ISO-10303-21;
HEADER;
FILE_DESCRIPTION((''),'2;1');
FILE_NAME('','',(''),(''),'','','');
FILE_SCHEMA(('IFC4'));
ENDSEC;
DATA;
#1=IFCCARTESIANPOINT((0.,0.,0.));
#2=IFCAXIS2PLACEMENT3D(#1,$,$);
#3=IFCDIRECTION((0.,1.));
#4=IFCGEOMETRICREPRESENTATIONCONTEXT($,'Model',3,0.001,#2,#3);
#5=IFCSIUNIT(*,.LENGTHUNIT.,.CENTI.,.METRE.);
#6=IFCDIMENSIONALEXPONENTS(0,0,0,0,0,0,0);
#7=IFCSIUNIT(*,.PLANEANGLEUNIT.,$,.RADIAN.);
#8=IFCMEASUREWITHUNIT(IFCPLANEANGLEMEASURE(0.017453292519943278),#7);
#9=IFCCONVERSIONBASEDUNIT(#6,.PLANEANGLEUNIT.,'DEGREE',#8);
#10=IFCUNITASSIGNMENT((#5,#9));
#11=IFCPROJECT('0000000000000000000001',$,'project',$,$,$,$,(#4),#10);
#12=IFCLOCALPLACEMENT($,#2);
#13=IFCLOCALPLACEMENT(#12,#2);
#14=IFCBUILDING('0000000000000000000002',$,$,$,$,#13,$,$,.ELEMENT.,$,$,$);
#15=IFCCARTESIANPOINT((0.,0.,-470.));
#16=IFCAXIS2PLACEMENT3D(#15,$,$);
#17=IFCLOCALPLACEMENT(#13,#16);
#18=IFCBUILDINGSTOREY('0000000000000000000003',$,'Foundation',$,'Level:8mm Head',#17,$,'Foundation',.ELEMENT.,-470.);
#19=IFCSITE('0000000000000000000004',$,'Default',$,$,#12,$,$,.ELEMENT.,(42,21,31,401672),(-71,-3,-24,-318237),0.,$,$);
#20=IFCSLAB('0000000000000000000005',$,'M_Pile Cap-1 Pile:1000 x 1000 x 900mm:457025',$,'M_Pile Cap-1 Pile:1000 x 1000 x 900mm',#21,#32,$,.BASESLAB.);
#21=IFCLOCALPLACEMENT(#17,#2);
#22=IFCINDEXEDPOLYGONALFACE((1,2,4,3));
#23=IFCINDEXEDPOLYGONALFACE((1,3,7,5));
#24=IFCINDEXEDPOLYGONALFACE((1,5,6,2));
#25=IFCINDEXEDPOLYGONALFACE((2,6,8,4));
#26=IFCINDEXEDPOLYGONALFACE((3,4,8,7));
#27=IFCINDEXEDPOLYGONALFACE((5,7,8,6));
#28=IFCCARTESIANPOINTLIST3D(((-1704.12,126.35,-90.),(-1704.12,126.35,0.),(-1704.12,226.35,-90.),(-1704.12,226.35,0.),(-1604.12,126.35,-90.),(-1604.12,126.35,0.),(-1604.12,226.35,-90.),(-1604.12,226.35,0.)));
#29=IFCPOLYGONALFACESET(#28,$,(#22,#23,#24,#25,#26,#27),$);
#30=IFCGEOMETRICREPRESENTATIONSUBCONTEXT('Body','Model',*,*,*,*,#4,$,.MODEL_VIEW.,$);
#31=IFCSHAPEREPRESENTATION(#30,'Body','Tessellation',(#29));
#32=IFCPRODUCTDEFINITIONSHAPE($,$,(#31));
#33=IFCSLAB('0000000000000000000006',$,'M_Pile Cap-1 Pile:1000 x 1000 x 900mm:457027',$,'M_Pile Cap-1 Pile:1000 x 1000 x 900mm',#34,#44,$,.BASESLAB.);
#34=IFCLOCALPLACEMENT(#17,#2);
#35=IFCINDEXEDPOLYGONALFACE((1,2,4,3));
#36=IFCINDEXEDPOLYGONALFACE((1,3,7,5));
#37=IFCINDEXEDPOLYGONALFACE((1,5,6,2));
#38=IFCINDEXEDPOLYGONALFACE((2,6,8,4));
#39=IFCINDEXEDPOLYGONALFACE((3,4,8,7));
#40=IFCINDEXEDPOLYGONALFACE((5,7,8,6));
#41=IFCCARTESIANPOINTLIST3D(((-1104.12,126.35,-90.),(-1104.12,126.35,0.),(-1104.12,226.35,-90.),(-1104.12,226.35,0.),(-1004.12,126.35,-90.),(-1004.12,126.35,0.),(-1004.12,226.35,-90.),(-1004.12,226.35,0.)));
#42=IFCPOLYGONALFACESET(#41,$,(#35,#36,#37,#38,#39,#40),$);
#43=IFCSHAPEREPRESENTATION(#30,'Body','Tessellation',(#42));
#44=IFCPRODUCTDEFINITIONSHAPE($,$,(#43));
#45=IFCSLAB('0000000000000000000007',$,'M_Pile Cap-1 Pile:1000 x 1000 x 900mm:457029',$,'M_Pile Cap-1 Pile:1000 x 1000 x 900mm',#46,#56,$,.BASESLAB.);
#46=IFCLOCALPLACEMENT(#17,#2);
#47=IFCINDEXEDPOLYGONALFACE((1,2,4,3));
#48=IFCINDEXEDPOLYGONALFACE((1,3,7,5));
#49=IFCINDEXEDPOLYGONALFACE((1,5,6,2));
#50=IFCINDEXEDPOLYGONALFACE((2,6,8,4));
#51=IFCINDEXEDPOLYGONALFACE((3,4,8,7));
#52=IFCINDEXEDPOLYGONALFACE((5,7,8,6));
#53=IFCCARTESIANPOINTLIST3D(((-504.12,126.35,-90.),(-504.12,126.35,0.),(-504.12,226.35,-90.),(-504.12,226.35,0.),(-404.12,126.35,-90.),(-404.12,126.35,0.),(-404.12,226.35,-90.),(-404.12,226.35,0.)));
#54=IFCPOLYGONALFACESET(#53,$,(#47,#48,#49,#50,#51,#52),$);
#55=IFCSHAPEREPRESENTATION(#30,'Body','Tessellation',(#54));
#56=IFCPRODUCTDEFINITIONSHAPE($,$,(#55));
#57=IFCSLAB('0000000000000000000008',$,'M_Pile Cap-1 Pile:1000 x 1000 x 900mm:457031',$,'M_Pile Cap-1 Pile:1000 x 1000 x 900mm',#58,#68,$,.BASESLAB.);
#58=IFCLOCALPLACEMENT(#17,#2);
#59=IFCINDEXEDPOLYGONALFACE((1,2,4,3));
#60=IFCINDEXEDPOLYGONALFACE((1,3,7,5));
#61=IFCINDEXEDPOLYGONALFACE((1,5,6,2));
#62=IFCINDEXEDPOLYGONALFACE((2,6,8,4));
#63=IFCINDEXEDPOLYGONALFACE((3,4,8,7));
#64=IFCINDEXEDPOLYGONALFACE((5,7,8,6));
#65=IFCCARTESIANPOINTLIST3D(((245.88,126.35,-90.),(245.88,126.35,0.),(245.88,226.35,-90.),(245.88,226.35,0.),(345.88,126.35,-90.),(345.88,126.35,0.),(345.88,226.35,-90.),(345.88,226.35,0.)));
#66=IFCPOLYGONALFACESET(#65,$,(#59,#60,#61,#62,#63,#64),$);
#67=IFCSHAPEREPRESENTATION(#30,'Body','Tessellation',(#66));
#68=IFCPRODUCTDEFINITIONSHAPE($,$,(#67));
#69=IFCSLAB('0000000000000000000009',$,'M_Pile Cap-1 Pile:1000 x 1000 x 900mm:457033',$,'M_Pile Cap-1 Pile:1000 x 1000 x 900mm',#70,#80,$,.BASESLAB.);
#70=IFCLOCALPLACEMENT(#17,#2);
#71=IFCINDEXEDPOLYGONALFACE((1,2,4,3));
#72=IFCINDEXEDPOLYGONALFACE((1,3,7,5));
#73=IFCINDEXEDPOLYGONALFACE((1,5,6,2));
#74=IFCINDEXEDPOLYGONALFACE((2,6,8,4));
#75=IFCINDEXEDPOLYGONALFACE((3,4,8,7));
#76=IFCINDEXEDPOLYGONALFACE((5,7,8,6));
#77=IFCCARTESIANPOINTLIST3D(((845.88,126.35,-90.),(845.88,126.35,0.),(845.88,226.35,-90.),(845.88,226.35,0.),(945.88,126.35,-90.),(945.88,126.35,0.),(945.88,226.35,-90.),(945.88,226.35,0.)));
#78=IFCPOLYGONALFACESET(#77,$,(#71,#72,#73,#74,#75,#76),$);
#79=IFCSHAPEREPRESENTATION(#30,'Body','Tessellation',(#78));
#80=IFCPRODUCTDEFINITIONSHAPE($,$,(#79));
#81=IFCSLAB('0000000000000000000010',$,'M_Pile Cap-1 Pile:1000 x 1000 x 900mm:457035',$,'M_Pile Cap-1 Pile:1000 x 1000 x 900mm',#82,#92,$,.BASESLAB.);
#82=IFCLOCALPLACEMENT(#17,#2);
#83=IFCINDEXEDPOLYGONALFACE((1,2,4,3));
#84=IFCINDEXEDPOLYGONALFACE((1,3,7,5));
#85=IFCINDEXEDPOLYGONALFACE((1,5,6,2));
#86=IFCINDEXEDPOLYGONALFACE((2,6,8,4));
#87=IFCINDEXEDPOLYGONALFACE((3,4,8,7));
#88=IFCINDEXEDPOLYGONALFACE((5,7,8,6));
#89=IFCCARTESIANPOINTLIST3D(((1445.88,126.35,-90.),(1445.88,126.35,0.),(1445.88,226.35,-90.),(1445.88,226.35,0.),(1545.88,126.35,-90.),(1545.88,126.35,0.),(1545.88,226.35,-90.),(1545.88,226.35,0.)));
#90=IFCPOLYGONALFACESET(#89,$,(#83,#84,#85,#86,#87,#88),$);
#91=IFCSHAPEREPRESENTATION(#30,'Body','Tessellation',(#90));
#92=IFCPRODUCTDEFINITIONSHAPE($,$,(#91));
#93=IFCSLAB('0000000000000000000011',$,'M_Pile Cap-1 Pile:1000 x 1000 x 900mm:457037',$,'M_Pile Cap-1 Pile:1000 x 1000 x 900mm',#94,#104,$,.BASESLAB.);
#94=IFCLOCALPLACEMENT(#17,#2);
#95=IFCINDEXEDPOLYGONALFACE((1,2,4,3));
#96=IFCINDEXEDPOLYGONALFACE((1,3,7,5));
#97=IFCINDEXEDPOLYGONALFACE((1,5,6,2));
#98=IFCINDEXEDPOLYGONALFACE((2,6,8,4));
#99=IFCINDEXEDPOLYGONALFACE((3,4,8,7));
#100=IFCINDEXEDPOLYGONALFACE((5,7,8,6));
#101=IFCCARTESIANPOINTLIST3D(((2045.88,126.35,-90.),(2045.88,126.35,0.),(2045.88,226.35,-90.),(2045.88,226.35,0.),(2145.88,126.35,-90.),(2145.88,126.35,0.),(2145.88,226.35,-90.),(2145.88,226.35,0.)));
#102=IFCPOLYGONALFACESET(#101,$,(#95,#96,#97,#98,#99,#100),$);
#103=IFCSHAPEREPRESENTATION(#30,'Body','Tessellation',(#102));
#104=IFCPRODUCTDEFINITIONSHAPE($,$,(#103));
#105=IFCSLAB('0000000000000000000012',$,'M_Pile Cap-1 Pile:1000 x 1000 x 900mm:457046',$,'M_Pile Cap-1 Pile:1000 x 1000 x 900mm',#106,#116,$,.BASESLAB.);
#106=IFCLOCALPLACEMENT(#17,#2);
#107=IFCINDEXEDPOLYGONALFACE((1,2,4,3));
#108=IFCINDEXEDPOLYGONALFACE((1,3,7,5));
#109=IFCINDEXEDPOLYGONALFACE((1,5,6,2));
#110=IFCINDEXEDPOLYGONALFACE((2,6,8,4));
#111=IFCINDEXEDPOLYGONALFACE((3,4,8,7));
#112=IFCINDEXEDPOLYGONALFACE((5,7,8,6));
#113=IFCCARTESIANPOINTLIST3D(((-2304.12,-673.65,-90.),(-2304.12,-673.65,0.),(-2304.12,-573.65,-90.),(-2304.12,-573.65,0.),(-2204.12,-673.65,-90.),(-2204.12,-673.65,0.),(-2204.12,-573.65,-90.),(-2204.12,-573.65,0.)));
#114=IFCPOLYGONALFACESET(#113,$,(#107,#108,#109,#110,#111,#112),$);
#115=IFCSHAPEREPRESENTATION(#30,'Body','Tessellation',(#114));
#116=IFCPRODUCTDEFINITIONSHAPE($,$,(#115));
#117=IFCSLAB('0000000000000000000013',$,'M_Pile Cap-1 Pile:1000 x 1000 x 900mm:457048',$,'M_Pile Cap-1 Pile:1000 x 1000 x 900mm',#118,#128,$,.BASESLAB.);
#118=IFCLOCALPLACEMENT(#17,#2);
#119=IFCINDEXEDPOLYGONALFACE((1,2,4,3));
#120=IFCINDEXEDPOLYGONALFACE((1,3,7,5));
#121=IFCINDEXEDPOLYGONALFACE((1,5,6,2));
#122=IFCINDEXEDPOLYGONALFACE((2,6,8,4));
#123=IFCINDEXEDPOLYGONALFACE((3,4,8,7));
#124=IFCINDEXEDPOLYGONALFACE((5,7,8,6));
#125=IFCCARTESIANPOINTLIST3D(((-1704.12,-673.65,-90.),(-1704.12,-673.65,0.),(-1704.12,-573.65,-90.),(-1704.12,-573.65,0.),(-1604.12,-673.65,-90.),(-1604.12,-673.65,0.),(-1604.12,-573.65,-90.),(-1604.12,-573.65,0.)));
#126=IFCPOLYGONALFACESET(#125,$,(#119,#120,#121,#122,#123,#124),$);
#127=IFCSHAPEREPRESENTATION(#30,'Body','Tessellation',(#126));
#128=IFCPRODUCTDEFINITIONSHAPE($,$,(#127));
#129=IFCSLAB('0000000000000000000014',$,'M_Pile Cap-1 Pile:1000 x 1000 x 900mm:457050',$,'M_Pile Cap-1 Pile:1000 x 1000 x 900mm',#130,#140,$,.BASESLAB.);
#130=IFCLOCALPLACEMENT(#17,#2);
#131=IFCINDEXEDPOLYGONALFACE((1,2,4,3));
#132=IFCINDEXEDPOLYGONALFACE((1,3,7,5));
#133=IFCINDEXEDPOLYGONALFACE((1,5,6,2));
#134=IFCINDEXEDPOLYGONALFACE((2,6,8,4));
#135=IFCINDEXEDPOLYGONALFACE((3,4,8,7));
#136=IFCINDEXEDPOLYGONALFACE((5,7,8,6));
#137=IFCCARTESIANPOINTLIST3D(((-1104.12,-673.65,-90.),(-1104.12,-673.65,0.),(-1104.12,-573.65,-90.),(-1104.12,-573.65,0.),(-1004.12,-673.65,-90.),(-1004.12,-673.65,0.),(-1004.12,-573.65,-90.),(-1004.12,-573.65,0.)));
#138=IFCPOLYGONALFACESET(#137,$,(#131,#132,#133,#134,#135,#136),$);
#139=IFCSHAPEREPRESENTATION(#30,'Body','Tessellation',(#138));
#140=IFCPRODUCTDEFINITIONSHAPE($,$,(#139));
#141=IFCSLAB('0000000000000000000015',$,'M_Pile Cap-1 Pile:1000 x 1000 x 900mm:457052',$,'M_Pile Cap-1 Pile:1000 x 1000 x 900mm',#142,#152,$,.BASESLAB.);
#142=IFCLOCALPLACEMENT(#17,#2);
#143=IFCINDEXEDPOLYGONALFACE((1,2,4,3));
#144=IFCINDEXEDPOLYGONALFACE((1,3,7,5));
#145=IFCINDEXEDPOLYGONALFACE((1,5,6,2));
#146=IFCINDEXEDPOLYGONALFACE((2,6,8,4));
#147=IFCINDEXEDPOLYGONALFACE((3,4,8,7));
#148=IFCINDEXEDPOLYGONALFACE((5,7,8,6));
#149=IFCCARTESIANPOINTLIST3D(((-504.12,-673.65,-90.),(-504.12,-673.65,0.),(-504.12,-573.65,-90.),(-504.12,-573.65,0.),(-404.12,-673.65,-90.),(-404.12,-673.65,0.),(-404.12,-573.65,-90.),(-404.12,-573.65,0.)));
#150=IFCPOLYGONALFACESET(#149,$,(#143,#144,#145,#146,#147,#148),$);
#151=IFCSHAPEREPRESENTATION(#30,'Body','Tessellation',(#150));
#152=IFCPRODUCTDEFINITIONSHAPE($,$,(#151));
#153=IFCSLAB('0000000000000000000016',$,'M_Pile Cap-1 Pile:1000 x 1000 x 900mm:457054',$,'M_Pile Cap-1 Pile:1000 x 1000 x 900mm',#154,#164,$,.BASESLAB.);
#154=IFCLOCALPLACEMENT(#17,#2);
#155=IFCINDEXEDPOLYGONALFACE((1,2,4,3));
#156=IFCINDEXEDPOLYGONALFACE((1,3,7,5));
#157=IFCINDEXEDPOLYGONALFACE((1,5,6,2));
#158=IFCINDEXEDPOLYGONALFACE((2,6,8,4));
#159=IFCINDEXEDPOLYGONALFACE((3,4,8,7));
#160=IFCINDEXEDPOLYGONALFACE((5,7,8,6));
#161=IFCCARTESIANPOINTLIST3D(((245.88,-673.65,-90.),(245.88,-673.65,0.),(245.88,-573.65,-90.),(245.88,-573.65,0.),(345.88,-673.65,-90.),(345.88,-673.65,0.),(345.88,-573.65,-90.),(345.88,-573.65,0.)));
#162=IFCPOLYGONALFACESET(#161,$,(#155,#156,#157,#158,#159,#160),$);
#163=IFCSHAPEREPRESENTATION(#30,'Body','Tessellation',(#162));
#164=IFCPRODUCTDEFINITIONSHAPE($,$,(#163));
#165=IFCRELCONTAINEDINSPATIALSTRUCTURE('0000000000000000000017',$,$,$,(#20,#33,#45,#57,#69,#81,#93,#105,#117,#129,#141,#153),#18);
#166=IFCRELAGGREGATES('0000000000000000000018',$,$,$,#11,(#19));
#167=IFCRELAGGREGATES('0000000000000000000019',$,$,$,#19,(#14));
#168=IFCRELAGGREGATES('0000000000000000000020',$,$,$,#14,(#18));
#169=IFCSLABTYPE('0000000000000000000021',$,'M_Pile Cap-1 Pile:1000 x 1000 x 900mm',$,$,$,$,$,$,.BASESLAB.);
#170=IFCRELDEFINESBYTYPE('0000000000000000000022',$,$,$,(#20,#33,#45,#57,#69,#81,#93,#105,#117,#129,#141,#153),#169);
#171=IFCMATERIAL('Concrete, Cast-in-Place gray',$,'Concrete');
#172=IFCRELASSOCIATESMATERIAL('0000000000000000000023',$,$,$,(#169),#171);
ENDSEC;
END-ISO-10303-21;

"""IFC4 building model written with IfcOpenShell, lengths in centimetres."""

from ifc_helpers import new_model, entity, si_unit, converted_unit, direction, frame, origin, place, context, subcontext, project, spatial, indexed_curve, outline, extrude, material, type_object, element, save


model = new_model("IFC4")

# Units and contexts
model_context = context("Model", 3, precision=0.001, world=origin(), true_north=direction((0.0, 1.0)))
body_context = subcontext(model_context, "Body", "Model", "MODEL_VIEW")
ifc_project = project(units=[si_unit("LENGTHUNIT", "METRE", prefix="CENTI"), converted_unit("PLANEANGLEUNIT", "DEGREE", entity("IfcPlaneAngleMeasure", 0.017453292519943278), si_unit("PLANEANGLEUNIT", "RADIAN"), dimensions=[0, 0, 0, 0, 0, 0, 0])], contexts=[model_context])

# Site, building, storey
site_placement = place(None, origin())
site = spatial("IfcSite", under=ifc_project, at=site_placement, Name="Default", CompositionType="ELEMENT", RefLatitude=(42, 21, 31, 401672), RefLongitude=(-71, -3, -24, -318237), RefElevation=0.0)
building_placement = place(site_placement, origin())
building = spatial("IfcBuilding", under=site, at=building_placement, CompositionType="ELEMENT")
storey_placement = place(building_placement, frame((0.0, 0.0, -470.0)))
storey = spatial("IfcBuildingStorey", under=building, at=storey_placement, Name="Foundation", ObjectType="Level:8mm Head", LongName="Foundation", CompositionType="ELEMENT", Elevation=-470.0)

# Slabs
ifc_material_1 = material(Name="Concrete, Cast-in-Place gray", Category="Concrete")
slab_type_1 = type_object("IfcSlabType", Name="M_Pile Cap-1 Pile:1000 x 1000 x 900mm", PredefinedType="BASESLAB", material=ifc_material_1)
slab_1_placement = place(storey_placement, origin())
element("IfcSlab", 1, at=slab_1_placement, inside=storey, type_object=slab_type_1, Name="M_Pile Cap-1 Pile:1000 x 1000 x 900mm:457025", ObjectType="M_Pile Cap-1 Pile:1000 x 1000 x 900mm", PredefinedType="BASESLAB", context=body_context, shape_type="SweptSolid", body=[
    extrude(outline(indexed_curve([(-50.0, -50.0), (50.0, -50.0), (50.0, 50.0), (-50.0, 50.0), (-50.0, -50.0)], self_intersect=False)), frame((-1654.12, 176.35, -90.0), z_axis=(0.0, 0.0, 1.0), x_axis=(-1.0, 0.0, 0.0)), (0.0, 0.0, 1.0), 90.0),
])
slab_2_placement = place(storey_placement, origin())
element("IfcSlab", 2, at=slab_2_placement, inside=storey, type_object=slab_type_1, Name="M_Pile Cap-1 Pile:1000 x 1000 x 900mm:457027", ObjectType="M_Pile Cap-1 Pile:1000 x 1000 x 900mm", PredefinedType="BASESLAB", context=body_context, shape_type="SweptSolid", body=[
    extrude(outline(indexed_curve([(-50.0, -50.0), (50.0, -50.0), (50.0, 50.0), (-50.0, 50.0), (-50.0, -50.0)], self_intersect=False)), frame((-1054.12, 176.35, -90.0), z_axis=(0.0, 0.0, 1.0), x_axis=(-1.0, 0.0, 0.0)), (0.0, 0.0, 1.0), 90.0),
])
slab_3_placement = place(storey_placement, origin())
element("IfcSlab", 3, at=slab_3_placement, inside=storey, type_object=slab_type_1, Name="M_Pile Cap-1 Pile:1000 x 1000 x 900mm:457029", ObjectType="M_Pile Cap-1 Pile:1000 x 1000 x 900mm", PredefinedType="BASESLAB", context=body_context, shape_type="SweptSolid", body=[
    extrude(outline(indexed_curve([(-50.0, -50.0), (50.0, -50.0), (50.0, 50.0), (-50.0, 50.0), (-50.0, -50.0)], self_intersect=False)), frame((-454.12, 176.35, -90.0), z_axis=(0.0, 0.0, 1.0), x_axis=(-1.0, 0.0, 0.0)), (0.0, 0.0, 1.0), 90.0),
])
slab_4_placement = place(storey_placement, origin())
element("IfcSlab", 4, at=slab_4_placement, inside=storey, type_object=slab_type_1, Name="M_Pile Cap-1 Pile:1000 x 1000 x 900mm:457031", ObjectType="M_Pile Cap-1 Pile:1000 x 1000 x 900mm", PredefinedType="BASESLAB", context=body_context, shape_type="SweptSolid", body=[
    extrude(outline(indexed_curve([(-50.0, -50.0), (50.0, -50.0), (50.0, 50.0), (-50.0, 50.0), (-50.0, -50.0)], self_intersect=False)), frame((295.88, 176.35, -90.0), z_axis=(0.0, 0.0, 1.0), x_axis=(-1.0, 0.0, 0.0)), (0.0, 0.0, 1.0), 90.0),
])
slab_5_placement = place(storey_placement, origin())
element("IfcSlab", 5, at=slab_5_placement, inside=storey, type_object=slab_type_1, Name="M_Pile Cap-1 Pile:1000 x 1000 x 900mm:457033", ObjectType="M_Pile Cap-1 Pile:1000 x 1000 x 900mm", PredefinedType="BASESLAB", context=body_context, shape_type="SweptSolid", body=[
    extrude(outline(indexed_curve([(-50.0, -50.0), (50.0, -50.0), (50.0, 50.0), (-50.0, 50.0), (-50.0, -50.0)], self_intersect=False)), frame((895.88, 176.35, -90.0), z_axis=(0.0, 0.0, 1.0), x_axis=(-1.0, 0.0, 0.0)), (0.0, 0.0, 1.0), 90.0),
])
slab_6_placement = place(storey_placement, origin())
element("IfcSlab", 6, at=slab_6_placement, inside=storey, type_object=slab_type_1, Name="M_Pile Cap-1 Pile:1000 x 1000 x 900mm:457035", ObjectType="M_Pile Cap-1 Pile:1000 x 1000 x 900mm", PredefinedType="BASESLAB", context=body_context, shape_type="SweptSolid", body=[
    extrude(outline(indexed_curve([(-50.0, -50.0), (50.0, -50.0), (50.0, 50.0), (-50.0, 50.0), (-50.0, -50.0)], self_intersect=False)), frame((1495.88, 176.35, -90.0), z_axis=(0.0, 0.0, 1.0), x_axis=(-1.0, 0.0, 0.0)), (0.0, 0.0, 1.0), 90.0),
])
slab_7_placement = place(storey_placement, origin())
element("IfcSlab", 7, at=slab_7_placement, inside=storey, type_object=slab_type_1, Name="M_Pile Cap-1 Pile:1000 x 1000 x 900mm:457037", ObjectType="M_Pile Cap-1 Pile:1000 x 1000 x 900mm", PredefinedType="BASESLAB", context=body_context, shape_type="SweptSolid", body=[
    extrude(outline(indexed_curve([(-50.0, -50.0), (50.0, -50.0), (50.0, 50.0), (-50.0, 50.0), (-50.0, -50.0)], self_intersect=False)), frame((2095.88, 176.35, -90.0), z_axis=(0.0, 0.0, 1.0), x_axis=(-1.0, 0.0, 0.0)), (0.0, 0.0, 1.0), 90.0),
])
slab_8_placement = place(storey_placement, origin())
element("IfcSlab", 8, at=slab_8_placement, inside=storey, type_object=slab_type_1, Name="M_Pile Cap-1 Pile:1000 x 1000 x 900mm:457046", ObjectType="M_Pile Cap-1 Pile:1000 x 1000 x 900mm", PredefinedType="BASESLAB", context=body_context, shape_type="SweptSolid", body=[
    extrude(outline(indexed_curve([(-50.0, -50.0), (50.0, -50.0), (50.0, 50.0), (-50.0, 50.0), (-50.0, -50.0)], self_intersect=False)), frame((-2254.12, -623.65, -90.0), z_axis=(0.0, 0.0, 1.0), x_axis=(-1.0, 0.0, 0.0)), (0.0, 0.0, 1.0), 90.0),
])
slab_9_placement = place(storey_placement, origin())
element("IfcSlab", 9, at=slab_9_placement, inside=storey, type_object=slab_type_1, Name="M_Pile Cap-1 Pile:1000 x 1000 x 900mm:457048", ObjectType="M_Pile Cap-1 Pile:1000 x 1000 x 900mm", PredefinedType="BASESLAB", context=body_context, shape_type="SweptSolid", body=[
    extrude(outline(indexed_curve([(-50.0, -50.0), (50.0, -50.0), (50.0, 50.0), (-50.0, 50.0), (-50.0, -50.0)], self_intersect=False)), frame((-1654.12, -623.65, -90.0), z_axis=(0.0, 0.0, 1.0), x_axis=(-1.0, 0.0, 0.0)), (0.0, 0.0, 1.0), 90.0),
])
slab_10_placement = place(storey_placement, origin())
element("IfcSlab", 10, at=slab_10_placement, inside=storey, type_object=slab_type_1, Name="M_Pile Cap-1 Pile:1000 x 1000 x 900mm:457050", ObjectType="M_Pile Cap-1 Pile:1000 x 1000 x 900mm", PredefinedType="BASESLAB", context=body_context, shape_type="SweptSolid", body=[
    extrude(outline(indexed_curve([(-50.0, -50.0), (50.0, -50.0), (50.0, 50.0), (-50.0, 50.0), (-50.0, -50.0)], self_intersect=False)), frame((-1054.12, -623.65, -90.0), z_axis=(0.0, 0.0, 1.0), x_axis=(-1.0, 0.0, 0.0)), (0.0, 0.0, 1.0), 90.0),
])
slab_11_placement = place(storey_placement, origin())
element("IfcSlab", 11, at=slab_11_placement, inside=storey, type_object=slab_type_1, Name="M_Pile Cap-1 Pile:1000 x 1000 x 900mm:457052", ObjectType="M_Pile Cap-1 Pile:1000 x 1000 x 900mm", PredefinedType="BASESLAB", context=body_context, shape_type="SweptSolid", body=[
    extrude(outline(indexed_curve([(-50.0, -50.0), (50.0, -50.0), (50.0, 50.0), (-50.0, 50.0), (-50.0, -50.0)], self_intersect=False)), frame((-454.12, -623.65, -90.0), z_axis=(0.0, 0.0, 1.0), x_axis=(-1.0, 0.0, 0.0)), (0.0, 0.0, 1.0), 90.0),
])
slab_12_placement = place(storey_placement, origin())
element("IfcSlab", 12, at=slab_12_placement, inside=storey, type_object=slab_type_1, Name="M_Pile Cap-1 Pile:1000 x 1000 x 900mm:457054", ObjectType="M_Pile Cap-1 Pile:1000 x 1000 x 900mm", PredefinedType="BASESLAB", context=body_context, shape_type="SweptSolid", body=[
    extrude(outline(indexed_curve([(-50.0, -50.0), (50.0, -50.0), (50.0, 50.0), (-50.0, 50.0), (-50.0, -50.0)], self_intersect=False)), frame((295.88, -623.65, -90.0), z_axis=(0.0, 0.0, 1.0), x_axis=(-1.0, 0.0, 0.0)), (0.0, 0.0, 1.0), 90.0),
])

save(model, "model.ifc")
